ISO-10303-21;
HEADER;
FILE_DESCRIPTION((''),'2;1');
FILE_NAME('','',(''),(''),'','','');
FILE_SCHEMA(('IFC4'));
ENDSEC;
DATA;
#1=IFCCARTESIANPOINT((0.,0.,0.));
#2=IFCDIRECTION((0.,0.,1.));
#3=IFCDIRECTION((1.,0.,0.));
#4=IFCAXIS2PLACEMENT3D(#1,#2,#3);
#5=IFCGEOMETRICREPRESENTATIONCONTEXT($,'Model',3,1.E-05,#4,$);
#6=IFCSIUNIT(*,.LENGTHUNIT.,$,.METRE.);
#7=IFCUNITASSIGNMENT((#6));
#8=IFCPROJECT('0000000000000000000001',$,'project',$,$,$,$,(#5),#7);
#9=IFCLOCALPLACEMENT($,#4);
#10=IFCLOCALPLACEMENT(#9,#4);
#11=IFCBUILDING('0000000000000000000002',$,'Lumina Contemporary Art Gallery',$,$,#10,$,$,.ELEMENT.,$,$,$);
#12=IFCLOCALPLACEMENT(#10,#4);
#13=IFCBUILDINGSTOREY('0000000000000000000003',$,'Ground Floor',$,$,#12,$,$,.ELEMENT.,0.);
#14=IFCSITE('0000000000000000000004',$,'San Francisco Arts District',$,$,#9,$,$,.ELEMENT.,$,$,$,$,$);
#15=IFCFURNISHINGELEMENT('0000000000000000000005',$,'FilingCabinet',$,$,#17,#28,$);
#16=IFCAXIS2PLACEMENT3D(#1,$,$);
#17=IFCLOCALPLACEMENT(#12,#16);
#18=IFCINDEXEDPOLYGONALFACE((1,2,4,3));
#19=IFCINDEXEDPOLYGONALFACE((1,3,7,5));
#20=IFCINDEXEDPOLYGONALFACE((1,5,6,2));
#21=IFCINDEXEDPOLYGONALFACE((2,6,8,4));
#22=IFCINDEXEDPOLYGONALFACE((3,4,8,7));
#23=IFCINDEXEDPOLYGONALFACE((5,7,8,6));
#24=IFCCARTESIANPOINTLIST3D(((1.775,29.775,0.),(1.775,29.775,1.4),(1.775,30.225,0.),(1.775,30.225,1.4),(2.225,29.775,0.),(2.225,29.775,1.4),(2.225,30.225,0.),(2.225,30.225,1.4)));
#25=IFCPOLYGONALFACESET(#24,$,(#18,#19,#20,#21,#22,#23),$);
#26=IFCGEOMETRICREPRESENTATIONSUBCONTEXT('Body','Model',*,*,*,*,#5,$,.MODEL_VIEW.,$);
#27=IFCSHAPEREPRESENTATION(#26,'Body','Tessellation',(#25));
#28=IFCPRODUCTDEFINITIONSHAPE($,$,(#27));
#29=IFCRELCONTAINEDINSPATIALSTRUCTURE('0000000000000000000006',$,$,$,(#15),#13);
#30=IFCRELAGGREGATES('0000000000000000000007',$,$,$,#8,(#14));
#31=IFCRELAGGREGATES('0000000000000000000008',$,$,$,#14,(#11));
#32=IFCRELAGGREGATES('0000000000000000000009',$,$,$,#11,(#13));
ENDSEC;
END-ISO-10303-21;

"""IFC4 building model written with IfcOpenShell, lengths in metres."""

from ifc_helpers import new_model, si_unit, origin_with_axes, place, context, subcontext, project, spatial, polyline, outline, extrude, element, save


model = new_model("IFC4")

# Units and contexts
model_context = context("Model", 3, precision=1e-05, world=origin_with_axes())
body_context = subcontext(model_context, "Body", "Model", "MODEL_VIEW")
ifc_project = project(units=[si_unit("LENGTHUNIT", "METRE")], contexts=[model_context])

# Site, building, storey
site_placement = place(None, origin_with_axes())
site = spatial("IfcSite", under=ifc_project, at=site_placement, Name="San Francisco Arts District", CompositionType="ELEMENT")
building_placement = place(site_placement, origin_with_axes())
building = spatial("IfcBuilding", under=site, at=building_placement, Name="Lumina Contemporary Art Gallery", CompositionType="ELEMENT")
storey_placement = place(building_placement, origin_with_axes())
storey = spatial("IfcBuildingStorey", under=building, at=storey_placement, Name="Ground Floor", CompositionType="ELEMENT", Elevation=0.0)

# Furnishing element
furnishing_1_placement = place(storey_placement, origin_with_axes())
element("IfcFurnishingElement", 1, at=furnishing_1_placement, inside=storey, Name="FilingCabinet", context=body_context, shape_type="SweptSolid", body=[
    extrude(outline(polyline([(1.775, 30.225, 0.0), (1.775, 29.775, 0.0), (2.225, 29.775, 0.0), (2.225, 30.225, 0.0), (1.775, 30.225, 0.0)])), None, (0.0, 0.0, 1.0), 1.4),
])

save(model, "model.ifc")
